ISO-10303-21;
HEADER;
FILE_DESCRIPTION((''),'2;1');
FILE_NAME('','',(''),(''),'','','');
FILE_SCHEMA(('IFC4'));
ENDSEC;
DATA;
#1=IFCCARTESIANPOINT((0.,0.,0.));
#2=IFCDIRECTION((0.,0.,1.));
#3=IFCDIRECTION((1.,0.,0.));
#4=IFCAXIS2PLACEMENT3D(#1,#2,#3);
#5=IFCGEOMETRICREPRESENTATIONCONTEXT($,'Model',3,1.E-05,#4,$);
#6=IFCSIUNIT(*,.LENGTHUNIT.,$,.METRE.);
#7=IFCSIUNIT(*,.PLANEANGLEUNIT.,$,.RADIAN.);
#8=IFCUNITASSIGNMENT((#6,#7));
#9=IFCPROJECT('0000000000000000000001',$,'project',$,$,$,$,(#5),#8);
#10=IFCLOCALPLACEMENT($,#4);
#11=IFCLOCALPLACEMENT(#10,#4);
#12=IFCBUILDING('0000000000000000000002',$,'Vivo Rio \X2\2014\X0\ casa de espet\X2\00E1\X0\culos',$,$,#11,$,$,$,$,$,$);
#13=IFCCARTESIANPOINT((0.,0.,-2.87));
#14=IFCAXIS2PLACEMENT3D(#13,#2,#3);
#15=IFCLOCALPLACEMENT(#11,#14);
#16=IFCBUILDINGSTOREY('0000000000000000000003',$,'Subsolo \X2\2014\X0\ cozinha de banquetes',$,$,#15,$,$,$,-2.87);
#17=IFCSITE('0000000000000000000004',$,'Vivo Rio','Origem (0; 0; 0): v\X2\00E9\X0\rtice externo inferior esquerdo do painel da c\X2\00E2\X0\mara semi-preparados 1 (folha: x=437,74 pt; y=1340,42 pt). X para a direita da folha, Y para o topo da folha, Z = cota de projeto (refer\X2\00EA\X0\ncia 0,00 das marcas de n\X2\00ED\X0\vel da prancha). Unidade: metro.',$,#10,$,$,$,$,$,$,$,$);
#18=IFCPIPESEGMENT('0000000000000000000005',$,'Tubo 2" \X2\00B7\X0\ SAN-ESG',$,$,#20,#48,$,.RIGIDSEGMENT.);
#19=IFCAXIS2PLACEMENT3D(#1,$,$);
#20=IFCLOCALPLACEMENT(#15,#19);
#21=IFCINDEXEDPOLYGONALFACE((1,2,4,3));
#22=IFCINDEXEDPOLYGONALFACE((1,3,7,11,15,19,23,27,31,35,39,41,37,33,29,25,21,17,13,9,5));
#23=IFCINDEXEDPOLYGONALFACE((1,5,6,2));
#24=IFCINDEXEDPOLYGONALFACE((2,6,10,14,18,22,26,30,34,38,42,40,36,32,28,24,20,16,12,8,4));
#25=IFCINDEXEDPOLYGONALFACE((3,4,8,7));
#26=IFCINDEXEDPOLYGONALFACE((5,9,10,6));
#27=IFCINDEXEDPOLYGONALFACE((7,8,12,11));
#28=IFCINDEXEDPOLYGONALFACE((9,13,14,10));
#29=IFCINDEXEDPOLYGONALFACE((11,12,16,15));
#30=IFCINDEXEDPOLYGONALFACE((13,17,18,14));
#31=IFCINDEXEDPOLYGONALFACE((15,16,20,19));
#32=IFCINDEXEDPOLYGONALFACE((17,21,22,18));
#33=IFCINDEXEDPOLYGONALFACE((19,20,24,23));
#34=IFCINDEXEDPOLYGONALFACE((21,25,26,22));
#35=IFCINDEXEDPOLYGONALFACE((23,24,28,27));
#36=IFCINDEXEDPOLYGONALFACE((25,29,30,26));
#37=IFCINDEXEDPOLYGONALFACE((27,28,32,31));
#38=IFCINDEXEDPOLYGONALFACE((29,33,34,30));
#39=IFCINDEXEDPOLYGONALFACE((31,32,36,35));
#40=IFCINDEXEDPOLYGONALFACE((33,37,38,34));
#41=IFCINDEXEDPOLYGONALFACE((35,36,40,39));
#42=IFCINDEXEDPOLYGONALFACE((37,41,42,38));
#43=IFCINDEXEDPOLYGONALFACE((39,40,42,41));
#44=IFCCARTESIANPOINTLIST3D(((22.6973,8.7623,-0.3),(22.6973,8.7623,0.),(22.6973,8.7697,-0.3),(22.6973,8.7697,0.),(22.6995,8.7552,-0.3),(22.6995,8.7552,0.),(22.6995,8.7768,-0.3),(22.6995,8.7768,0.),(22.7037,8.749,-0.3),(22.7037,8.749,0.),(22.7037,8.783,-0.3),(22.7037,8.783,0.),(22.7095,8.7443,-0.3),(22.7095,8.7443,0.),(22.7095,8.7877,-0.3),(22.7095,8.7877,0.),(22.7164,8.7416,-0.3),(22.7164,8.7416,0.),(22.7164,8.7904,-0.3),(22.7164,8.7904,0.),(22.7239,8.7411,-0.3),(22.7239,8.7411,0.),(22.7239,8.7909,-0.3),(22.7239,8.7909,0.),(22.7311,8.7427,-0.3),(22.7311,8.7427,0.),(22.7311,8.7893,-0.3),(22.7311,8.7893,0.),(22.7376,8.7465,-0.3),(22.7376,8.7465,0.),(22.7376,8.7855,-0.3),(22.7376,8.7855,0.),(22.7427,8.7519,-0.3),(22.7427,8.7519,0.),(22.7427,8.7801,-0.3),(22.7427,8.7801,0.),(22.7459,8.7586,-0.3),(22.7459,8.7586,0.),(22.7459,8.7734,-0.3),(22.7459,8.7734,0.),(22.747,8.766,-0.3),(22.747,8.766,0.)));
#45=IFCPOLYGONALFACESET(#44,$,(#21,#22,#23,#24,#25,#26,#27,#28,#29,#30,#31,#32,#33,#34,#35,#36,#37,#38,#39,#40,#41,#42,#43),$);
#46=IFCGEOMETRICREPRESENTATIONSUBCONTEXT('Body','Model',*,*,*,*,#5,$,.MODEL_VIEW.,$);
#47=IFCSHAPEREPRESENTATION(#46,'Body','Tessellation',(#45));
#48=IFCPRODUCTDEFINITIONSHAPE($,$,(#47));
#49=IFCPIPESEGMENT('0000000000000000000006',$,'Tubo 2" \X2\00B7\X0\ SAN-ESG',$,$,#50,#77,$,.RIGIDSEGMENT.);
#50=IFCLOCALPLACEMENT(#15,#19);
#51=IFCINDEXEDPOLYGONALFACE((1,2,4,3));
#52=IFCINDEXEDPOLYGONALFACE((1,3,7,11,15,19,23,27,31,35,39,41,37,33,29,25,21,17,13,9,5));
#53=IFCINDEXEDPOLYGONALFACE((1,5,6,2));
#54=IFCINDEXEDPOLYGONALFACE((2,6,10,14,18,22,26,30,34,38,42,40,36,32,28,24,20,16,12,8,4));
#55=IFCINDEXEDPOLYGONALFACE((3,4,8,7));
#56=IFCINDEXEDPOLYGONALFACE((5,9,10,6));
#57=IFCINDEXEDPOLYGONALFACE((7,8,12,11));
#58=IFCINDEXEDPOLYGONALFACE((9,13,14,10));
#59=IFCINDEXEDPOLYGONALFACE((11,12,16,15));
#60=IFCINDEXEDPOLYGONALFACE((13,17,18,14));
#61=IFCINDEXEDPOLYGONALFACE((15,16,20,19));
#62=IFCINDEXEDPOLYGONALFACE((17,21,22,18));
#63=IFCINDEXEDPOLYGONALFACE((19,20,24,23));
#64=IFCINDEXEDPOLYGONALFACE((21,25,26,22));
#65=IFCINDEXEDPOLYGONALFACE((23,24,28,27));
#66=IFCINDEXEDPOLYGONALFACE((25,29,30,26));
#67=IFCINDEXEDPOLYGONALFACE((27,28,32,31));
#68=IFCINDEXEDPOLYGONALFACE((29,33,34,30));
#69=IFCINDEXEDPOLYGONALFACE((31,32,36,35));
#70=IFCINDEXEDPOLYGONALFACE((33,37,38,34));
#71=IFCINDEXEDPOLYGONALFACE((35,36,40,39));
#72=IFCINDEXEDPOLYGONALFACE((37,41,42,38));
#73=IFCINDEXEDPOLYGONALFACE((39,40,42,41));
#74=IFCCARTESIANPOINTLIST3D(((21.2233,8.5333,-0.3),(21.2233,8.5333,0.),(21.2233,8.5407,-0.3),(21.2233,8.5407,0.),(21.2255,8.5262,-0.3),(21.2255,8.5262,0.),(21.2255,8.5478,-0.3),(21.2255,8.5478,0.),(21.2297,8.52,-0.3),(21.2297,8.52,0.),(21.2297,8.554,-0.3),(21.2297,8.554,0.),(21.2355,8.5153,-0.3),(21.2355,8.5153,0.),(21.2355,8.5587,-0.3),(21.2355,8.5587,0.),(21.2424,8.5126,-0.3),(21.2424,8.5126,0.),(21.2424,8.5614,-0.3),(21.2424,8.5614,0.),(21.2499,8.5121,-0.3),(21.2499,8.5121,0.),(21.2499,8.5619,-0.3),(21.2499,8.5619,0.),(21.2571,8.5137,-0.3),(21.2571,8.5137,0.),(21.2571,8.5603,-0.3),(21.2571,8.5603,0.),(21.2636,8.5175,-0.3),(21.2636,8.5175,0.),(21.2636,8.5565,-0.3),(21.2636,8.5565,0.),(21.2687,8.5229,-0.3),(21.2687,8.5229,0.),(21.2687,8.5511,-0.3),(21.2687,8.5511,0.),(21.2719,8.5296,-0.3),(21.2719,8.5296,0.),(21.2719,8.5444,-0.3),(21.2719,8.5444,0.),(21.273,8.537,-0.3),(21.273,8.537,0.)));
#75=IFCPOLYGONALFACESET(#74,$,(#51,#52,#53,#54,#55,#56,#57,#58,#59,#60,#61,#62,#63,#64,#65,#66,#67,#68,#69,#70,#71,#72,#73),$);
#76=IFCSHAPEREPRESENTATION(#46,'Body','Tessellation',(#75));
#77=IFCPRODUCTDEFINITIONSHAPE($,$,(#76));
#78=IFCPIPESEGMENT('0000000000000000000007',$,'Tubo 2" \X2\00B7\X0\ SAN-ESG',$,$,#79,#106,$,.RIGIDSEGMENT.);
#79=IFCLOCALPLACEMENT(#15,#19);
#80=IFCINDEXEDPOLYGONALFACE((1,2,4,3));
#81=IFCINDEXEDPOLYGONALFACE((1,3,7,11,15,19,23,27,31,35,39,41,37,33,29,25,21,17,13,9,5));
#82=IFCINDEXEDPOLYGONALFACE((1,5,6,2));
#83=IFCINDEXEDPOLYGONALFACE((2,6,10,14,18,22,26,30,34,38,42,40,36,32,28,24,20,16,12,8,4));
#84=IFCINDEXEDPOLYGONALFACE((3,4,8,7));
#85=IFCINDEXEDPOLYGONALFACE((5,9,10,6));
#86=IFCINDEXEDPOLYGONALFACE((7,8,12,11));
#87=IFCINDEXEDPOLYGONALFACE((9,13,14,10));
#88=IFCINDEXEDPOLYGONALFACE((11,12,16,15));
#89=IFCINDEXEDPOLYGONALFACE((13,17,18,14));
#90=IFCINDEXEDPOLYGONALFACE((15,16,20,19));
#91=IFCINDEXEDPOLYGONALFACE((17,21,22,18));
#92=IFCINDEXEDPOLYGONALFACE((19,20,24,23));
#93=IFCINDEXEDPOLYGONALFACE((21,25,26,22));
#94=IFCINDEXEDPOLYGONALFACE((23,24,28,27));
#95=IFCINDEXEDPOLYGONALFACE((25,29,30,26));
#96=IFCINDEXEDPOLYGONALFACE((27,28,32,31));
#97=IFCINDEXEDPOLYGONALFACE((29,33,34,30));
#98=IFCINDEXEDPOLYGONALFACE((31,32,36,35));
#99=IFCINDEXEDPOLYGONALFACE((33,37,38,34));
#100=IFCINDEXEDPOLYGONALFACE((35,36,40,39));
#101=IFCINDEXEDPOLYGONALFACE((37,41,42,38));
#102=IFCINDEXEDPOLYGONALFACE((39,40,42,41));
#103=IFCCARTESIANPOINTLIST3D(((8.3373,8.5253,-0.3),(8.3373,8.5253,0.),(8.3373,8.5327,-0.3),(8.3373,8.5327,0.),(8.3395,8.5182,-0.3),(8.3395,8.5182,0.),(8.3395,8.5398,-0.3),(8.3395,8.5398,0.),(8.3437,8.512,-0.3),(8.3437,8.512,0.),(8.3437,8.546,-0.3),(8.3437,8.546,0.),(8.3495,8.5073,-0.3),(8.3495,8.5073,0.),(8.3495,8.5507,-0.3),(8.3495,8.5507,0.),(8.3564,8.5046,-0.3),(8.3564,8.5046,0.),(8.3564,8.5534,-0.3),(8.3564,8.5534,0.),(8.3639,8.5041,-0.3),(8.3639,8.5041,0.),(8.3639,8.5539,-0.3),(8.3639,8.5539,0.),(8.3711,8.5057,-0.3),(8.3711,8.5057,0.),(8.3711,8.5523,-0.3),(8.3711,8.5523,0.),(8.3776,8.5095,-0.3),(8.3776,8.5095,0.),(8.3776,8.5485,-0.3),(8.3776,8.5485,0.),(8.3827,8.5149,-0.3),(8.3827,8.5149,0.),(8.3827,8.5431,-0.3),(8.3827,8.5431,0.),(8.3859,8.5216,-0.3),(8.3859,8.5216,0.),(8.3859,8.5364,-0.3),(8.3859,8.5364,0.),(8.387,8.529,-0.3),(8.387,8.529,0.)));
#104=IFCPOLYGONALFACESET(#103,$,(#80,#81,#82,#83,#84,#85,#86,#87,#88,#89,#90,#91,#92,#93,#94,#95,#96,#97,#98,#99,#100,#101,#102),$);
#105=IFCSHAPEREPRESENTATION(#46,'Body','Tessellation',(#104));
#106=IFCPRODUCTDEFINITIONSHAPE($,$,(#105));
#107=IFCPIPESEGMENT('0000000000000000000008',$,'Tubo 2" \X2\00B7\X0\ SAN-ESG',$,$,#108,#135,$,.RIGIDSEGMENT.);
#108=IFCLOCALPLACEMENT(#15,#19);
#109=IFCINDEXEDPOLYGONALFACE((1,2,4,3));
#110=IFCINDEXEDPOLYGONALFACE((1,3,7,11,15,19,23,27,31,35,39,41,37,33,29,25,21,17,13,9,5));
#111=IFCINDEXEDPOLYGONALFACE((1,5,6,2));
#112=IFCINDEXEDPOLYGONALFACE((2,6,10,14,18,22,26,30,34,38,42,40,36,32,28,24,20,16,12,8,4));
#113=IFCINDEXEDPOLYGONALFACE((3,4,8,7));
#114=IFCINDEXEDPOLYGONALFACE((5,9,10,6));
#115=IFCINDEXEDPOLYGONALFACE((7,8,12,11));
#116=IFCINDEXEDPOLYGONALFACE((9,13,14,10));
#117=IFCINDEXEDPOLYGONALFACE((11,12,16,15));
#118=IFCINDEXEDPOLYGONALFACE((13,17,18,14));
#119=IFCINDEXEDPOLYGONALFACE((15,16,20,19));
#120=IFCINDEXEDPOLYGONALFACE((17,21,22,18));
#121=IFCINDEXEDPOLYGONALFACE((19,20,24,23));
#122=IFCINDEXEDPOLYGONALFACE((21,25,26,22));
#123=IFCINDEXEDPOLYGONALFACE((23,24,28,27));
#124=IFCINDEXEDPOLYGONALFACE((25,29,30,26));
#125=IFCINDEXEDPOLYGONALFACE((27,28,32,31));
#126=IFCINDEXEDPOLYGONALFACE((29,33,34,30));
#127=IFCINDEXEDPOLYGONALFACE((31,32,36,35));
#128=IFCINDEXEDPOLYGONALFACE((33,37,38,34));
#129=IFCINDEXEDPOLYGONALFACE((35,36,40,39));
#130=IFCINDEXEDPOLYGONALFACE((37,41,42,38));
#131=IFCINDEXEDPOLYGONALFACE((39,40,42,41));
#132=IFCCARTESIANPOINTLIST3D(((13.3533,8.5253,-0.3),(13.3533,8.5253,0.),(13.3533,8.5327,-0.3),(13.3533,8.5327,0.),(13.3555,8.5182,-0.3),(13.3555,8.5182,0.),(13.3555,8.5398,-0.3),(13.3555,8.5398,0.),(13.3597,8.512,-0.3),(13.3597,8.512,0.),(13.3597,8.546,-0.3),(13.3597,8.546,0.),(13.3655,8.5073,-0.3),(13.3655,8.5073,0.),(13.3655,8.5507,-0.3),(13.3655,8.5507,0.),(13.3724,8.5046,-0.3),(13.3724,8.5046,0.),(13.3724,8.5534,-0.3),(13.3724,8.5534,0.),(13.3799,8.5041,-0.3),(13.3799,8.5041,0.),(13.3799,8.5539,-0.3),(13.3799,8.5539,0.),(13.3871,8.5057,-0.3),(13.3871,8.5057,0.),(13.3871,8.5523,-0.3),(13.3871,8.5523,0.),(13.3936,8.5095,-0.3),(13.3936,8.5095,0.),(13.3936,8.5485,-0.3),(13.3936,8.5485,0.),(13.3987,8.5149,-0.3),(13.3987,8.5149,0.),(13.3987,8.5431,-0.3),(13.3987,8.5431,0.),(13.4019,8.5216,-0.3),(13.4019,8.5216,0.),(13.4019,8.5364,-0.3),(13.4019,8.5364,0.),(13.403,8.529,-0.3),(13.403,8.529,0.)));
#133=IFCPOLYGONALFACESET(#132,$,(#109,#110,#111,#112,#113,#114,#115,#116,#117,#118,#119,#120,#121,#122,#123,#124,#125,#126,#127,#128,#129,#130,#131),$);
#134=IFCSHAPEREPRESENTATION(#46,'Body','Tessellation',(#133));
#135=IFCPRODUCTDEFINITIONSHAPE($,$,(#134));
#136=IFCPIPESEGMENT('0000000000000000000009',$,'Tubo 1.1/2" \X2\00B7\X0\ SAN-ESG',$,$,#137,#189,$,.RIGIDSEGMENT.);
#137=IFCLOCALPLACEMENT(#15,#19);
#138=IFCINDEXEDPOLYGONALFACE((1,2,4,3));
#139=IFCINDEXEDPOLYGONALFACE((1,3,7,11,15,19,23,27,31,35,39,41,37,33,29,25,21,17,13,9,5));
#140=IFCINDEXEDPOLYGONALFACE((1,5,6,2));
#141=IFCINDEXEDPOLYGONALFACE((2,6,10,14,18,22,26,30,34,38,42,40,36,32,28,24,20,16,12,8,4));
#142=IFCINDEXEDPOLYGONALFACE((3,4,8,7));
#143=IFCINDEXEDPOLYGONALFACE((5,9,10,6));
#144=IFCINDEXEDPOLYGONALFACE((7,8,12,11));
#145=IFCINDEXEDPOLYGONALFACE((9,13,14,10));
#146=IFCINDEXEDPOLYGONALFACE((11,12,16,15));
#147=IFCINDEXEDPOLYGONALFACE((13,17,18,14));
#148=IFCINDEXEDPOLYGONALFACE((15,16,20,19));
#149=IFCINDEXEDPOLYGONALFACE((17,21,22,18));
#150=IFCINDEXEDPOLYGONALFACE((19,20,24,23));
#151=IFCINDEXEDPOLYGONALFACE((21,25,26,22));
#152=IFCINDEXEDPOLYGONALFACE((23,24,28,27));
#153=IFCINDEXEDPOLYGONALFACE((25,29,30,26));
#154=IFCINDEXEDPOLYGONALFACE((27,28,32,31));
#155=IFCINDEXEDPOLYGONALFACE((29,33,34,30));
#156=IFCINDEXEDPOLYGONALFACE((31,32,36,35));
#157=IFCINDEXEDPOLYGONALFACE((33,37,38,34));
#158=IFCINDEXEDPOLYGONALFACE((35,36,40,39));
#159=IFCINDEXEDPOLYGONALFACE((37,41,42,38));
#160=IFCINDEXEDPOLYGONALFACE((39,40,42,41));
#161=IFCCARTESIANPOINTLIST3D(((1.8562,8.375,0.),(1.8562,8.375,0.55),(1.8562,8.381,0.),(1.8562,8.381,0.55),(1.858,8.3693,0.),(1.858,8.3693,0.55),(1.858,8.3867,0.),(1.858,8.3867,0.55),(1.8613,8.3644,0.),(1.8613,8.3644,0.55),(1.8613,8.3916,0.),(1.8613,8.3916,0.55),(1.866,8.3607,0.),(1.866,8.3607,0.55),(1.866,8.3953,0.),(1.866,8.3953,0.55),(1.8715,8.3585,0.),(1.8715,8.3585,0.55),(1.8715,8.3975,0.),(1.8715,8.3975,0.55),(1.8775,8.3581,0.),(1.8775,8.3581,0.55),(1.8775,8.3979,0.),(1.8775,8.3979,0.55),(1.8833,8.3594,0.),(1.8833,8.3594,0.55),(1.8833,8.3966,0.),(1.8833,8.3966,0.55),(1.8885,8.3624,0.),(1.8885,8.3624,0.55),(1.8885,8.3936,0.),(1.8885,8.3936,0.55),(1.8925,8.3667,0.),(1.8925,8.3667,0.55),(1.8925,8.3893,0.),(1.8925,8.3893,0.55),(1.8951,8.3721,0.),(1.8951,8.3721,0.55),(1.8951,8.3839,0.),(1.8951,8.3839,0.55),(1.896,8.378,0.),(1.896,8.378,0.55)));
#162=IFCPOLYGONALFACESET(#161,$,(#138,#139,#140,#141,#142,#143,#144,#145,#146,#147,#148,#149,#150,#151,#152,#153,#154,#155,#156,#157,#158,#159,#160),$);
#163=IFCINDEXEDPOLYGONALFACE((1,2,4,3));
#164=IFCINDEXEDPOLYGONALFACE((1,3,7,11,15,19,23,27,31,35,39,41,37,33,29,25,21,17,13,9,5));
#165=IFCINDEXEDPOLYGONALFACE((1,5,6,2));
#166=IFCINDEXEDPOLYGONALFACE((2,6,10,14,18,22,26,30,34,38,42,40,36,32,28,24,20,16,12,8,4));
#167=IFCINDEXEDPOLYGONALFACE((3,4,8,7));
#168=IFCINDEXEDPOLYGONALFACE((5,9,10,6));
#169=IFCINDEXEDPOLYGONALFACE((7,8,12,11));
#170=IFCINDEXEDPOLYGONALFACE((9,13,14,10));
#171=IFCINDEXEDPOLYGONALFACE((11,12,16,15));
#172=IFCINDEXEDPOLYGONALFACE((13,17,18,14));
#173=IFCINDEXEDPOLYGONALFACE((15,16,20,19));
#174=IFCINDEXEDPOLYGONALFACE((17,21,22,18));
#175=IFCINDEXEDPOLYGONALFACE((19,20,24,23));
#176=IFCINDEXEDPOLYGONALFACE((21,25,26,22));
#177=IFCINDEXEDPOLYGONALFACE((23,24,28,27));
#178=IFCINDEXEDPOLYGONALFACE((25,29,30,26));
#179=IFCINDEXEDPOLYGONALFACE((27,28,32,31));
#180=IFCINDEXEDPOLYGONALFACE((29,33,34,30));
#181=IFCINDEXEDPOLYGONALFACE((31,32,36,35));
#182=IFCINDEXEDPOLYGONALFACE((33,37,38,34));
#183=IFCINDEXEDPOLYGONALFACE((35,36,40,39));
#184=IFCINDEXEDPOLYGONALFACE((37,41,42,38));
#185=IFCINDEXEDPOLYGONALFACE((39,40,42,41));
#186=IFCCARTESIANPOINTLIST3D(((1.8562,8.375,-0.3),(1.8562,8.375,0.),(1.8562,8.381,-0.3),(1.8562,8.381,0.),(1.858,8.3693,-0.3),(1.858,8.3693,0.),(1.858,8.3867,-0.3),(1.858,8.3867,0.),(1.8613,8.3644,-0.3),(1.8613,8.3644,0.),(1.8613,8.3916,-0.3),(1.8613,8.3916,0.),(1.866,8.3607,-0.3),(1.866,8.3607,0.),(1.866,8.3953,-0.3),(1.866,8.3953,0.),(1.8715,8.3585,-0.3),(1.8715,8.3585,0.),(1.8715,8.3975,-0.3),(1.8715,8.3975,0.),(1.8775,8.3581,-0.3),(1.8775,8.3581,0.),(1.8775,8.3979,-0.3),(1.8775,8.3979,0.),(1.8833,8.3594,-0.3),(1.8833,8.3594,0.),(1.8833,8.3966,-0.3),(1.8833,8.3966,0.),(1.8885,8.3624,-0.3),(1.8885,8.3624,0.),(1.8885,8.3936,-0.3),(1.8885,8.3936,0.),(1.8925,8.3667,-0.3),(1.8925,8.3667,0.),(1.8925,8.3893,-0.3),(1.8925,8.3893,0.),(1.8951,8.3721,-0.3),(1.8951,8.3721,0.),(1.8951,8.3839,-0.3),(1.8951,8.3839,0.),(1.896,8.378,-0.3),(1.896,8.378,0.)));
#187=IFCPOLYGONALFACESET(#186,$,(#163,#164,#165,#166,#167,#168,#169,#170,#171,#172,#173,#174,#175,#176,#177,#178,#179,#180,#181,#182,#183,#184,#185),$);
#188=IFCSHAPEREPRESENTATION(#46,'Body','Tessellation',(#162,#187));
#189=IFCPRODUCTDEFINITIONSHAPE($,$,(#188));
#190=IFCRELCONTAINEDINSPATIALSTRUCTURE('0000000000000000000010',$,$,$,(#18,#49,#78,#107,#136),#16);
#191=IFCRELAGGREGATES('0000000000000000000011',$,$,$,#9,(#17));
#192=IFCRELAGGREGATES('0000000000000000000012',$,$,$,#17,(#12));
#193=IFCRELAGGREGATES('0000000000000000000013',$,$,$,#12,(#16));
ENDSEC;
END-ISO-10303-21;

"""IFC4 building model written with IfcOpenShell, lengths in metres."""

from ifc_helpers import new_model, si_unit, frame, origin_with_axes, origin_2d, place, context, subcontext, project, spatial, circle, extrude, element, save


model = new_model("IFC4")

# Units and contexts
model_context = context("Model", 3, precision=1e-05, world=origin_with_axes())
body_context = subcontext(model_context, "Body", "Model", "MODEL_VIEW")
ifc_project = project(units=[si_unit("LENGTHUNIT", "METRE"), si_unit("PLANEANGLEUNIT", "RADIAN")], contexts=[model_context])

# Site, building, storey
site_placement = place(None, origin_with_axes())
site = spatial("IfcSite", under=ifc_project, at=site_placement, Name="Vivo Rio", Description="Origem (0; 0; 0): vértice externo inferior esquerdo do painel da câmara semi-preparados 1 (folha: x=437,74 pt; y=1340,42 pt). X para a direita da folha, Y para o topo da folha, Z = cota de projeto (referência 0,00 das marcas de nível da prancha). Unidade: metro.")
building_placement = place(site_placement, origin_with_axes())
building = spatial("IfcBuilding", under=site, at=building_placement, Name="Vivo Rio — casa de espetáculos")
storey_placement = place(building_placement, frame((0.0, 0.0, -2.87), z_axis=(0.0, 0.0, 1.0), x_axis=(1.0, 0.0, 0.0)))
storey = spatial("IfcBuildingStorey", under=building, at=storey_placement, Name="Subsolo — cozinha de banquetes", Elevation=-2.87)

# Pipe segments
pipe_segment_1_placement = place(storey_placement, origin_with_axes())
element("IfcPipeSegment", 1, at=pipe_segment_1_placement, inside=storey, Name="Tubo 2\" · SAN-ESG", PredefinedType="RIGIDSEGMENT", context=body_context, shape_type="SweptSolid", body=[
    extrude(circle(Radius=0.025, at=origin_2d()), frame((22.722, 8.766, 0.0), z_axis=(0.0, 0.0, -1.0), x_axis=(1.0, 0.0, 0.0)), (0.0, 0.0, 1.0), 0.3),
])
pipe_segment_2_placement = place(storey_placement, origin_with_axes())
element("IfcPipeSegment", 2, at=pipe_segment_2_placement, inside=storey, Name="Tubo 2\" · SAN-ESG", PredefinedType="RIGIDSEGMENT", context=body_context, shape_type="SweptSolid", body=[
    extrude(circle(Radius=0.025, at=origin_2d()), frame((21.248, 8.537, 0.0), z_axis=(0.0, 0.0, -1.0), x_axis=(1.0, 0.0, 0.0)), (0.0, 0.0, 1.0), 0.3),
])
pipe_segment_3_placement = place(storey_placement, origin_with_axes())
element("IfcPipeSegment", 3, at=pipe_segment_3_placement, inside=storey, Name="Tubo 2\" · SAN-ESG", PredefinedType="RIGIDSEGMENT", context=body_context, shape_type="SweptSolid", body=[
    extrude(circle(Radius=0.025, at=origin_2d()), frame((8.362, 8.529, 0.0), z_axis=(0.0, 0.0, -1.0), x_axis=(1.0, 0.0, 0.0)), (0.0, 0.0, 1.0), 0.3),
])
pipe_segment_4_placement = place(storey_placement, origin_with_axes())
element("IfcPipeSegment", 4, at=pipe_segment_4_placement, inside=storey, Name="Tubo 2\" · SAN-ESG", PredefinedType="RIGIDSEGMENT", context=body_context, shape_type="SweptSolid", body=[
    extrude(circle(Radius=0.025, at=origin_2d()), frame((13.378, 8.529, 0.0), z_axis=(0.0, 0.0, -1.0), x_axis=(1.0, 0.0, 0.0)), (0.0, 0.0, 1.0), 0.3),
])
pipe_segment_5_placement = place(storey_placement, origin_with_axes())
element("IfcPipeSegment", 5, at=pipe_segment_5_placement, inside=storey, Name="Tubo 1.1/2\" · SAN-ESG", PredefinedType="RIGIDSEGMENT", context=body_context, shape_type="SweptSolid", body=[
    extrude(circle(Radius=0.02, at=origin_2d()), frame((1.876, 8.378, 0.55), z_axis=(0.0, 0.0, -1.0), x_axis=(1.0, 0.0, 0.0)), (0.0, 0.0, 1.0), 0.55),
    extrude(circle(Radius=0.02, at=origin_2d()), frame((1.876, 8.378, 0.0), z_axis=(0.0, 0.0, -1.0), x_axis=(1.0, 0.0, 0.0)), (0.0, 0.0, 1.0), 0.3),
])

save(model, "model.ifc")
